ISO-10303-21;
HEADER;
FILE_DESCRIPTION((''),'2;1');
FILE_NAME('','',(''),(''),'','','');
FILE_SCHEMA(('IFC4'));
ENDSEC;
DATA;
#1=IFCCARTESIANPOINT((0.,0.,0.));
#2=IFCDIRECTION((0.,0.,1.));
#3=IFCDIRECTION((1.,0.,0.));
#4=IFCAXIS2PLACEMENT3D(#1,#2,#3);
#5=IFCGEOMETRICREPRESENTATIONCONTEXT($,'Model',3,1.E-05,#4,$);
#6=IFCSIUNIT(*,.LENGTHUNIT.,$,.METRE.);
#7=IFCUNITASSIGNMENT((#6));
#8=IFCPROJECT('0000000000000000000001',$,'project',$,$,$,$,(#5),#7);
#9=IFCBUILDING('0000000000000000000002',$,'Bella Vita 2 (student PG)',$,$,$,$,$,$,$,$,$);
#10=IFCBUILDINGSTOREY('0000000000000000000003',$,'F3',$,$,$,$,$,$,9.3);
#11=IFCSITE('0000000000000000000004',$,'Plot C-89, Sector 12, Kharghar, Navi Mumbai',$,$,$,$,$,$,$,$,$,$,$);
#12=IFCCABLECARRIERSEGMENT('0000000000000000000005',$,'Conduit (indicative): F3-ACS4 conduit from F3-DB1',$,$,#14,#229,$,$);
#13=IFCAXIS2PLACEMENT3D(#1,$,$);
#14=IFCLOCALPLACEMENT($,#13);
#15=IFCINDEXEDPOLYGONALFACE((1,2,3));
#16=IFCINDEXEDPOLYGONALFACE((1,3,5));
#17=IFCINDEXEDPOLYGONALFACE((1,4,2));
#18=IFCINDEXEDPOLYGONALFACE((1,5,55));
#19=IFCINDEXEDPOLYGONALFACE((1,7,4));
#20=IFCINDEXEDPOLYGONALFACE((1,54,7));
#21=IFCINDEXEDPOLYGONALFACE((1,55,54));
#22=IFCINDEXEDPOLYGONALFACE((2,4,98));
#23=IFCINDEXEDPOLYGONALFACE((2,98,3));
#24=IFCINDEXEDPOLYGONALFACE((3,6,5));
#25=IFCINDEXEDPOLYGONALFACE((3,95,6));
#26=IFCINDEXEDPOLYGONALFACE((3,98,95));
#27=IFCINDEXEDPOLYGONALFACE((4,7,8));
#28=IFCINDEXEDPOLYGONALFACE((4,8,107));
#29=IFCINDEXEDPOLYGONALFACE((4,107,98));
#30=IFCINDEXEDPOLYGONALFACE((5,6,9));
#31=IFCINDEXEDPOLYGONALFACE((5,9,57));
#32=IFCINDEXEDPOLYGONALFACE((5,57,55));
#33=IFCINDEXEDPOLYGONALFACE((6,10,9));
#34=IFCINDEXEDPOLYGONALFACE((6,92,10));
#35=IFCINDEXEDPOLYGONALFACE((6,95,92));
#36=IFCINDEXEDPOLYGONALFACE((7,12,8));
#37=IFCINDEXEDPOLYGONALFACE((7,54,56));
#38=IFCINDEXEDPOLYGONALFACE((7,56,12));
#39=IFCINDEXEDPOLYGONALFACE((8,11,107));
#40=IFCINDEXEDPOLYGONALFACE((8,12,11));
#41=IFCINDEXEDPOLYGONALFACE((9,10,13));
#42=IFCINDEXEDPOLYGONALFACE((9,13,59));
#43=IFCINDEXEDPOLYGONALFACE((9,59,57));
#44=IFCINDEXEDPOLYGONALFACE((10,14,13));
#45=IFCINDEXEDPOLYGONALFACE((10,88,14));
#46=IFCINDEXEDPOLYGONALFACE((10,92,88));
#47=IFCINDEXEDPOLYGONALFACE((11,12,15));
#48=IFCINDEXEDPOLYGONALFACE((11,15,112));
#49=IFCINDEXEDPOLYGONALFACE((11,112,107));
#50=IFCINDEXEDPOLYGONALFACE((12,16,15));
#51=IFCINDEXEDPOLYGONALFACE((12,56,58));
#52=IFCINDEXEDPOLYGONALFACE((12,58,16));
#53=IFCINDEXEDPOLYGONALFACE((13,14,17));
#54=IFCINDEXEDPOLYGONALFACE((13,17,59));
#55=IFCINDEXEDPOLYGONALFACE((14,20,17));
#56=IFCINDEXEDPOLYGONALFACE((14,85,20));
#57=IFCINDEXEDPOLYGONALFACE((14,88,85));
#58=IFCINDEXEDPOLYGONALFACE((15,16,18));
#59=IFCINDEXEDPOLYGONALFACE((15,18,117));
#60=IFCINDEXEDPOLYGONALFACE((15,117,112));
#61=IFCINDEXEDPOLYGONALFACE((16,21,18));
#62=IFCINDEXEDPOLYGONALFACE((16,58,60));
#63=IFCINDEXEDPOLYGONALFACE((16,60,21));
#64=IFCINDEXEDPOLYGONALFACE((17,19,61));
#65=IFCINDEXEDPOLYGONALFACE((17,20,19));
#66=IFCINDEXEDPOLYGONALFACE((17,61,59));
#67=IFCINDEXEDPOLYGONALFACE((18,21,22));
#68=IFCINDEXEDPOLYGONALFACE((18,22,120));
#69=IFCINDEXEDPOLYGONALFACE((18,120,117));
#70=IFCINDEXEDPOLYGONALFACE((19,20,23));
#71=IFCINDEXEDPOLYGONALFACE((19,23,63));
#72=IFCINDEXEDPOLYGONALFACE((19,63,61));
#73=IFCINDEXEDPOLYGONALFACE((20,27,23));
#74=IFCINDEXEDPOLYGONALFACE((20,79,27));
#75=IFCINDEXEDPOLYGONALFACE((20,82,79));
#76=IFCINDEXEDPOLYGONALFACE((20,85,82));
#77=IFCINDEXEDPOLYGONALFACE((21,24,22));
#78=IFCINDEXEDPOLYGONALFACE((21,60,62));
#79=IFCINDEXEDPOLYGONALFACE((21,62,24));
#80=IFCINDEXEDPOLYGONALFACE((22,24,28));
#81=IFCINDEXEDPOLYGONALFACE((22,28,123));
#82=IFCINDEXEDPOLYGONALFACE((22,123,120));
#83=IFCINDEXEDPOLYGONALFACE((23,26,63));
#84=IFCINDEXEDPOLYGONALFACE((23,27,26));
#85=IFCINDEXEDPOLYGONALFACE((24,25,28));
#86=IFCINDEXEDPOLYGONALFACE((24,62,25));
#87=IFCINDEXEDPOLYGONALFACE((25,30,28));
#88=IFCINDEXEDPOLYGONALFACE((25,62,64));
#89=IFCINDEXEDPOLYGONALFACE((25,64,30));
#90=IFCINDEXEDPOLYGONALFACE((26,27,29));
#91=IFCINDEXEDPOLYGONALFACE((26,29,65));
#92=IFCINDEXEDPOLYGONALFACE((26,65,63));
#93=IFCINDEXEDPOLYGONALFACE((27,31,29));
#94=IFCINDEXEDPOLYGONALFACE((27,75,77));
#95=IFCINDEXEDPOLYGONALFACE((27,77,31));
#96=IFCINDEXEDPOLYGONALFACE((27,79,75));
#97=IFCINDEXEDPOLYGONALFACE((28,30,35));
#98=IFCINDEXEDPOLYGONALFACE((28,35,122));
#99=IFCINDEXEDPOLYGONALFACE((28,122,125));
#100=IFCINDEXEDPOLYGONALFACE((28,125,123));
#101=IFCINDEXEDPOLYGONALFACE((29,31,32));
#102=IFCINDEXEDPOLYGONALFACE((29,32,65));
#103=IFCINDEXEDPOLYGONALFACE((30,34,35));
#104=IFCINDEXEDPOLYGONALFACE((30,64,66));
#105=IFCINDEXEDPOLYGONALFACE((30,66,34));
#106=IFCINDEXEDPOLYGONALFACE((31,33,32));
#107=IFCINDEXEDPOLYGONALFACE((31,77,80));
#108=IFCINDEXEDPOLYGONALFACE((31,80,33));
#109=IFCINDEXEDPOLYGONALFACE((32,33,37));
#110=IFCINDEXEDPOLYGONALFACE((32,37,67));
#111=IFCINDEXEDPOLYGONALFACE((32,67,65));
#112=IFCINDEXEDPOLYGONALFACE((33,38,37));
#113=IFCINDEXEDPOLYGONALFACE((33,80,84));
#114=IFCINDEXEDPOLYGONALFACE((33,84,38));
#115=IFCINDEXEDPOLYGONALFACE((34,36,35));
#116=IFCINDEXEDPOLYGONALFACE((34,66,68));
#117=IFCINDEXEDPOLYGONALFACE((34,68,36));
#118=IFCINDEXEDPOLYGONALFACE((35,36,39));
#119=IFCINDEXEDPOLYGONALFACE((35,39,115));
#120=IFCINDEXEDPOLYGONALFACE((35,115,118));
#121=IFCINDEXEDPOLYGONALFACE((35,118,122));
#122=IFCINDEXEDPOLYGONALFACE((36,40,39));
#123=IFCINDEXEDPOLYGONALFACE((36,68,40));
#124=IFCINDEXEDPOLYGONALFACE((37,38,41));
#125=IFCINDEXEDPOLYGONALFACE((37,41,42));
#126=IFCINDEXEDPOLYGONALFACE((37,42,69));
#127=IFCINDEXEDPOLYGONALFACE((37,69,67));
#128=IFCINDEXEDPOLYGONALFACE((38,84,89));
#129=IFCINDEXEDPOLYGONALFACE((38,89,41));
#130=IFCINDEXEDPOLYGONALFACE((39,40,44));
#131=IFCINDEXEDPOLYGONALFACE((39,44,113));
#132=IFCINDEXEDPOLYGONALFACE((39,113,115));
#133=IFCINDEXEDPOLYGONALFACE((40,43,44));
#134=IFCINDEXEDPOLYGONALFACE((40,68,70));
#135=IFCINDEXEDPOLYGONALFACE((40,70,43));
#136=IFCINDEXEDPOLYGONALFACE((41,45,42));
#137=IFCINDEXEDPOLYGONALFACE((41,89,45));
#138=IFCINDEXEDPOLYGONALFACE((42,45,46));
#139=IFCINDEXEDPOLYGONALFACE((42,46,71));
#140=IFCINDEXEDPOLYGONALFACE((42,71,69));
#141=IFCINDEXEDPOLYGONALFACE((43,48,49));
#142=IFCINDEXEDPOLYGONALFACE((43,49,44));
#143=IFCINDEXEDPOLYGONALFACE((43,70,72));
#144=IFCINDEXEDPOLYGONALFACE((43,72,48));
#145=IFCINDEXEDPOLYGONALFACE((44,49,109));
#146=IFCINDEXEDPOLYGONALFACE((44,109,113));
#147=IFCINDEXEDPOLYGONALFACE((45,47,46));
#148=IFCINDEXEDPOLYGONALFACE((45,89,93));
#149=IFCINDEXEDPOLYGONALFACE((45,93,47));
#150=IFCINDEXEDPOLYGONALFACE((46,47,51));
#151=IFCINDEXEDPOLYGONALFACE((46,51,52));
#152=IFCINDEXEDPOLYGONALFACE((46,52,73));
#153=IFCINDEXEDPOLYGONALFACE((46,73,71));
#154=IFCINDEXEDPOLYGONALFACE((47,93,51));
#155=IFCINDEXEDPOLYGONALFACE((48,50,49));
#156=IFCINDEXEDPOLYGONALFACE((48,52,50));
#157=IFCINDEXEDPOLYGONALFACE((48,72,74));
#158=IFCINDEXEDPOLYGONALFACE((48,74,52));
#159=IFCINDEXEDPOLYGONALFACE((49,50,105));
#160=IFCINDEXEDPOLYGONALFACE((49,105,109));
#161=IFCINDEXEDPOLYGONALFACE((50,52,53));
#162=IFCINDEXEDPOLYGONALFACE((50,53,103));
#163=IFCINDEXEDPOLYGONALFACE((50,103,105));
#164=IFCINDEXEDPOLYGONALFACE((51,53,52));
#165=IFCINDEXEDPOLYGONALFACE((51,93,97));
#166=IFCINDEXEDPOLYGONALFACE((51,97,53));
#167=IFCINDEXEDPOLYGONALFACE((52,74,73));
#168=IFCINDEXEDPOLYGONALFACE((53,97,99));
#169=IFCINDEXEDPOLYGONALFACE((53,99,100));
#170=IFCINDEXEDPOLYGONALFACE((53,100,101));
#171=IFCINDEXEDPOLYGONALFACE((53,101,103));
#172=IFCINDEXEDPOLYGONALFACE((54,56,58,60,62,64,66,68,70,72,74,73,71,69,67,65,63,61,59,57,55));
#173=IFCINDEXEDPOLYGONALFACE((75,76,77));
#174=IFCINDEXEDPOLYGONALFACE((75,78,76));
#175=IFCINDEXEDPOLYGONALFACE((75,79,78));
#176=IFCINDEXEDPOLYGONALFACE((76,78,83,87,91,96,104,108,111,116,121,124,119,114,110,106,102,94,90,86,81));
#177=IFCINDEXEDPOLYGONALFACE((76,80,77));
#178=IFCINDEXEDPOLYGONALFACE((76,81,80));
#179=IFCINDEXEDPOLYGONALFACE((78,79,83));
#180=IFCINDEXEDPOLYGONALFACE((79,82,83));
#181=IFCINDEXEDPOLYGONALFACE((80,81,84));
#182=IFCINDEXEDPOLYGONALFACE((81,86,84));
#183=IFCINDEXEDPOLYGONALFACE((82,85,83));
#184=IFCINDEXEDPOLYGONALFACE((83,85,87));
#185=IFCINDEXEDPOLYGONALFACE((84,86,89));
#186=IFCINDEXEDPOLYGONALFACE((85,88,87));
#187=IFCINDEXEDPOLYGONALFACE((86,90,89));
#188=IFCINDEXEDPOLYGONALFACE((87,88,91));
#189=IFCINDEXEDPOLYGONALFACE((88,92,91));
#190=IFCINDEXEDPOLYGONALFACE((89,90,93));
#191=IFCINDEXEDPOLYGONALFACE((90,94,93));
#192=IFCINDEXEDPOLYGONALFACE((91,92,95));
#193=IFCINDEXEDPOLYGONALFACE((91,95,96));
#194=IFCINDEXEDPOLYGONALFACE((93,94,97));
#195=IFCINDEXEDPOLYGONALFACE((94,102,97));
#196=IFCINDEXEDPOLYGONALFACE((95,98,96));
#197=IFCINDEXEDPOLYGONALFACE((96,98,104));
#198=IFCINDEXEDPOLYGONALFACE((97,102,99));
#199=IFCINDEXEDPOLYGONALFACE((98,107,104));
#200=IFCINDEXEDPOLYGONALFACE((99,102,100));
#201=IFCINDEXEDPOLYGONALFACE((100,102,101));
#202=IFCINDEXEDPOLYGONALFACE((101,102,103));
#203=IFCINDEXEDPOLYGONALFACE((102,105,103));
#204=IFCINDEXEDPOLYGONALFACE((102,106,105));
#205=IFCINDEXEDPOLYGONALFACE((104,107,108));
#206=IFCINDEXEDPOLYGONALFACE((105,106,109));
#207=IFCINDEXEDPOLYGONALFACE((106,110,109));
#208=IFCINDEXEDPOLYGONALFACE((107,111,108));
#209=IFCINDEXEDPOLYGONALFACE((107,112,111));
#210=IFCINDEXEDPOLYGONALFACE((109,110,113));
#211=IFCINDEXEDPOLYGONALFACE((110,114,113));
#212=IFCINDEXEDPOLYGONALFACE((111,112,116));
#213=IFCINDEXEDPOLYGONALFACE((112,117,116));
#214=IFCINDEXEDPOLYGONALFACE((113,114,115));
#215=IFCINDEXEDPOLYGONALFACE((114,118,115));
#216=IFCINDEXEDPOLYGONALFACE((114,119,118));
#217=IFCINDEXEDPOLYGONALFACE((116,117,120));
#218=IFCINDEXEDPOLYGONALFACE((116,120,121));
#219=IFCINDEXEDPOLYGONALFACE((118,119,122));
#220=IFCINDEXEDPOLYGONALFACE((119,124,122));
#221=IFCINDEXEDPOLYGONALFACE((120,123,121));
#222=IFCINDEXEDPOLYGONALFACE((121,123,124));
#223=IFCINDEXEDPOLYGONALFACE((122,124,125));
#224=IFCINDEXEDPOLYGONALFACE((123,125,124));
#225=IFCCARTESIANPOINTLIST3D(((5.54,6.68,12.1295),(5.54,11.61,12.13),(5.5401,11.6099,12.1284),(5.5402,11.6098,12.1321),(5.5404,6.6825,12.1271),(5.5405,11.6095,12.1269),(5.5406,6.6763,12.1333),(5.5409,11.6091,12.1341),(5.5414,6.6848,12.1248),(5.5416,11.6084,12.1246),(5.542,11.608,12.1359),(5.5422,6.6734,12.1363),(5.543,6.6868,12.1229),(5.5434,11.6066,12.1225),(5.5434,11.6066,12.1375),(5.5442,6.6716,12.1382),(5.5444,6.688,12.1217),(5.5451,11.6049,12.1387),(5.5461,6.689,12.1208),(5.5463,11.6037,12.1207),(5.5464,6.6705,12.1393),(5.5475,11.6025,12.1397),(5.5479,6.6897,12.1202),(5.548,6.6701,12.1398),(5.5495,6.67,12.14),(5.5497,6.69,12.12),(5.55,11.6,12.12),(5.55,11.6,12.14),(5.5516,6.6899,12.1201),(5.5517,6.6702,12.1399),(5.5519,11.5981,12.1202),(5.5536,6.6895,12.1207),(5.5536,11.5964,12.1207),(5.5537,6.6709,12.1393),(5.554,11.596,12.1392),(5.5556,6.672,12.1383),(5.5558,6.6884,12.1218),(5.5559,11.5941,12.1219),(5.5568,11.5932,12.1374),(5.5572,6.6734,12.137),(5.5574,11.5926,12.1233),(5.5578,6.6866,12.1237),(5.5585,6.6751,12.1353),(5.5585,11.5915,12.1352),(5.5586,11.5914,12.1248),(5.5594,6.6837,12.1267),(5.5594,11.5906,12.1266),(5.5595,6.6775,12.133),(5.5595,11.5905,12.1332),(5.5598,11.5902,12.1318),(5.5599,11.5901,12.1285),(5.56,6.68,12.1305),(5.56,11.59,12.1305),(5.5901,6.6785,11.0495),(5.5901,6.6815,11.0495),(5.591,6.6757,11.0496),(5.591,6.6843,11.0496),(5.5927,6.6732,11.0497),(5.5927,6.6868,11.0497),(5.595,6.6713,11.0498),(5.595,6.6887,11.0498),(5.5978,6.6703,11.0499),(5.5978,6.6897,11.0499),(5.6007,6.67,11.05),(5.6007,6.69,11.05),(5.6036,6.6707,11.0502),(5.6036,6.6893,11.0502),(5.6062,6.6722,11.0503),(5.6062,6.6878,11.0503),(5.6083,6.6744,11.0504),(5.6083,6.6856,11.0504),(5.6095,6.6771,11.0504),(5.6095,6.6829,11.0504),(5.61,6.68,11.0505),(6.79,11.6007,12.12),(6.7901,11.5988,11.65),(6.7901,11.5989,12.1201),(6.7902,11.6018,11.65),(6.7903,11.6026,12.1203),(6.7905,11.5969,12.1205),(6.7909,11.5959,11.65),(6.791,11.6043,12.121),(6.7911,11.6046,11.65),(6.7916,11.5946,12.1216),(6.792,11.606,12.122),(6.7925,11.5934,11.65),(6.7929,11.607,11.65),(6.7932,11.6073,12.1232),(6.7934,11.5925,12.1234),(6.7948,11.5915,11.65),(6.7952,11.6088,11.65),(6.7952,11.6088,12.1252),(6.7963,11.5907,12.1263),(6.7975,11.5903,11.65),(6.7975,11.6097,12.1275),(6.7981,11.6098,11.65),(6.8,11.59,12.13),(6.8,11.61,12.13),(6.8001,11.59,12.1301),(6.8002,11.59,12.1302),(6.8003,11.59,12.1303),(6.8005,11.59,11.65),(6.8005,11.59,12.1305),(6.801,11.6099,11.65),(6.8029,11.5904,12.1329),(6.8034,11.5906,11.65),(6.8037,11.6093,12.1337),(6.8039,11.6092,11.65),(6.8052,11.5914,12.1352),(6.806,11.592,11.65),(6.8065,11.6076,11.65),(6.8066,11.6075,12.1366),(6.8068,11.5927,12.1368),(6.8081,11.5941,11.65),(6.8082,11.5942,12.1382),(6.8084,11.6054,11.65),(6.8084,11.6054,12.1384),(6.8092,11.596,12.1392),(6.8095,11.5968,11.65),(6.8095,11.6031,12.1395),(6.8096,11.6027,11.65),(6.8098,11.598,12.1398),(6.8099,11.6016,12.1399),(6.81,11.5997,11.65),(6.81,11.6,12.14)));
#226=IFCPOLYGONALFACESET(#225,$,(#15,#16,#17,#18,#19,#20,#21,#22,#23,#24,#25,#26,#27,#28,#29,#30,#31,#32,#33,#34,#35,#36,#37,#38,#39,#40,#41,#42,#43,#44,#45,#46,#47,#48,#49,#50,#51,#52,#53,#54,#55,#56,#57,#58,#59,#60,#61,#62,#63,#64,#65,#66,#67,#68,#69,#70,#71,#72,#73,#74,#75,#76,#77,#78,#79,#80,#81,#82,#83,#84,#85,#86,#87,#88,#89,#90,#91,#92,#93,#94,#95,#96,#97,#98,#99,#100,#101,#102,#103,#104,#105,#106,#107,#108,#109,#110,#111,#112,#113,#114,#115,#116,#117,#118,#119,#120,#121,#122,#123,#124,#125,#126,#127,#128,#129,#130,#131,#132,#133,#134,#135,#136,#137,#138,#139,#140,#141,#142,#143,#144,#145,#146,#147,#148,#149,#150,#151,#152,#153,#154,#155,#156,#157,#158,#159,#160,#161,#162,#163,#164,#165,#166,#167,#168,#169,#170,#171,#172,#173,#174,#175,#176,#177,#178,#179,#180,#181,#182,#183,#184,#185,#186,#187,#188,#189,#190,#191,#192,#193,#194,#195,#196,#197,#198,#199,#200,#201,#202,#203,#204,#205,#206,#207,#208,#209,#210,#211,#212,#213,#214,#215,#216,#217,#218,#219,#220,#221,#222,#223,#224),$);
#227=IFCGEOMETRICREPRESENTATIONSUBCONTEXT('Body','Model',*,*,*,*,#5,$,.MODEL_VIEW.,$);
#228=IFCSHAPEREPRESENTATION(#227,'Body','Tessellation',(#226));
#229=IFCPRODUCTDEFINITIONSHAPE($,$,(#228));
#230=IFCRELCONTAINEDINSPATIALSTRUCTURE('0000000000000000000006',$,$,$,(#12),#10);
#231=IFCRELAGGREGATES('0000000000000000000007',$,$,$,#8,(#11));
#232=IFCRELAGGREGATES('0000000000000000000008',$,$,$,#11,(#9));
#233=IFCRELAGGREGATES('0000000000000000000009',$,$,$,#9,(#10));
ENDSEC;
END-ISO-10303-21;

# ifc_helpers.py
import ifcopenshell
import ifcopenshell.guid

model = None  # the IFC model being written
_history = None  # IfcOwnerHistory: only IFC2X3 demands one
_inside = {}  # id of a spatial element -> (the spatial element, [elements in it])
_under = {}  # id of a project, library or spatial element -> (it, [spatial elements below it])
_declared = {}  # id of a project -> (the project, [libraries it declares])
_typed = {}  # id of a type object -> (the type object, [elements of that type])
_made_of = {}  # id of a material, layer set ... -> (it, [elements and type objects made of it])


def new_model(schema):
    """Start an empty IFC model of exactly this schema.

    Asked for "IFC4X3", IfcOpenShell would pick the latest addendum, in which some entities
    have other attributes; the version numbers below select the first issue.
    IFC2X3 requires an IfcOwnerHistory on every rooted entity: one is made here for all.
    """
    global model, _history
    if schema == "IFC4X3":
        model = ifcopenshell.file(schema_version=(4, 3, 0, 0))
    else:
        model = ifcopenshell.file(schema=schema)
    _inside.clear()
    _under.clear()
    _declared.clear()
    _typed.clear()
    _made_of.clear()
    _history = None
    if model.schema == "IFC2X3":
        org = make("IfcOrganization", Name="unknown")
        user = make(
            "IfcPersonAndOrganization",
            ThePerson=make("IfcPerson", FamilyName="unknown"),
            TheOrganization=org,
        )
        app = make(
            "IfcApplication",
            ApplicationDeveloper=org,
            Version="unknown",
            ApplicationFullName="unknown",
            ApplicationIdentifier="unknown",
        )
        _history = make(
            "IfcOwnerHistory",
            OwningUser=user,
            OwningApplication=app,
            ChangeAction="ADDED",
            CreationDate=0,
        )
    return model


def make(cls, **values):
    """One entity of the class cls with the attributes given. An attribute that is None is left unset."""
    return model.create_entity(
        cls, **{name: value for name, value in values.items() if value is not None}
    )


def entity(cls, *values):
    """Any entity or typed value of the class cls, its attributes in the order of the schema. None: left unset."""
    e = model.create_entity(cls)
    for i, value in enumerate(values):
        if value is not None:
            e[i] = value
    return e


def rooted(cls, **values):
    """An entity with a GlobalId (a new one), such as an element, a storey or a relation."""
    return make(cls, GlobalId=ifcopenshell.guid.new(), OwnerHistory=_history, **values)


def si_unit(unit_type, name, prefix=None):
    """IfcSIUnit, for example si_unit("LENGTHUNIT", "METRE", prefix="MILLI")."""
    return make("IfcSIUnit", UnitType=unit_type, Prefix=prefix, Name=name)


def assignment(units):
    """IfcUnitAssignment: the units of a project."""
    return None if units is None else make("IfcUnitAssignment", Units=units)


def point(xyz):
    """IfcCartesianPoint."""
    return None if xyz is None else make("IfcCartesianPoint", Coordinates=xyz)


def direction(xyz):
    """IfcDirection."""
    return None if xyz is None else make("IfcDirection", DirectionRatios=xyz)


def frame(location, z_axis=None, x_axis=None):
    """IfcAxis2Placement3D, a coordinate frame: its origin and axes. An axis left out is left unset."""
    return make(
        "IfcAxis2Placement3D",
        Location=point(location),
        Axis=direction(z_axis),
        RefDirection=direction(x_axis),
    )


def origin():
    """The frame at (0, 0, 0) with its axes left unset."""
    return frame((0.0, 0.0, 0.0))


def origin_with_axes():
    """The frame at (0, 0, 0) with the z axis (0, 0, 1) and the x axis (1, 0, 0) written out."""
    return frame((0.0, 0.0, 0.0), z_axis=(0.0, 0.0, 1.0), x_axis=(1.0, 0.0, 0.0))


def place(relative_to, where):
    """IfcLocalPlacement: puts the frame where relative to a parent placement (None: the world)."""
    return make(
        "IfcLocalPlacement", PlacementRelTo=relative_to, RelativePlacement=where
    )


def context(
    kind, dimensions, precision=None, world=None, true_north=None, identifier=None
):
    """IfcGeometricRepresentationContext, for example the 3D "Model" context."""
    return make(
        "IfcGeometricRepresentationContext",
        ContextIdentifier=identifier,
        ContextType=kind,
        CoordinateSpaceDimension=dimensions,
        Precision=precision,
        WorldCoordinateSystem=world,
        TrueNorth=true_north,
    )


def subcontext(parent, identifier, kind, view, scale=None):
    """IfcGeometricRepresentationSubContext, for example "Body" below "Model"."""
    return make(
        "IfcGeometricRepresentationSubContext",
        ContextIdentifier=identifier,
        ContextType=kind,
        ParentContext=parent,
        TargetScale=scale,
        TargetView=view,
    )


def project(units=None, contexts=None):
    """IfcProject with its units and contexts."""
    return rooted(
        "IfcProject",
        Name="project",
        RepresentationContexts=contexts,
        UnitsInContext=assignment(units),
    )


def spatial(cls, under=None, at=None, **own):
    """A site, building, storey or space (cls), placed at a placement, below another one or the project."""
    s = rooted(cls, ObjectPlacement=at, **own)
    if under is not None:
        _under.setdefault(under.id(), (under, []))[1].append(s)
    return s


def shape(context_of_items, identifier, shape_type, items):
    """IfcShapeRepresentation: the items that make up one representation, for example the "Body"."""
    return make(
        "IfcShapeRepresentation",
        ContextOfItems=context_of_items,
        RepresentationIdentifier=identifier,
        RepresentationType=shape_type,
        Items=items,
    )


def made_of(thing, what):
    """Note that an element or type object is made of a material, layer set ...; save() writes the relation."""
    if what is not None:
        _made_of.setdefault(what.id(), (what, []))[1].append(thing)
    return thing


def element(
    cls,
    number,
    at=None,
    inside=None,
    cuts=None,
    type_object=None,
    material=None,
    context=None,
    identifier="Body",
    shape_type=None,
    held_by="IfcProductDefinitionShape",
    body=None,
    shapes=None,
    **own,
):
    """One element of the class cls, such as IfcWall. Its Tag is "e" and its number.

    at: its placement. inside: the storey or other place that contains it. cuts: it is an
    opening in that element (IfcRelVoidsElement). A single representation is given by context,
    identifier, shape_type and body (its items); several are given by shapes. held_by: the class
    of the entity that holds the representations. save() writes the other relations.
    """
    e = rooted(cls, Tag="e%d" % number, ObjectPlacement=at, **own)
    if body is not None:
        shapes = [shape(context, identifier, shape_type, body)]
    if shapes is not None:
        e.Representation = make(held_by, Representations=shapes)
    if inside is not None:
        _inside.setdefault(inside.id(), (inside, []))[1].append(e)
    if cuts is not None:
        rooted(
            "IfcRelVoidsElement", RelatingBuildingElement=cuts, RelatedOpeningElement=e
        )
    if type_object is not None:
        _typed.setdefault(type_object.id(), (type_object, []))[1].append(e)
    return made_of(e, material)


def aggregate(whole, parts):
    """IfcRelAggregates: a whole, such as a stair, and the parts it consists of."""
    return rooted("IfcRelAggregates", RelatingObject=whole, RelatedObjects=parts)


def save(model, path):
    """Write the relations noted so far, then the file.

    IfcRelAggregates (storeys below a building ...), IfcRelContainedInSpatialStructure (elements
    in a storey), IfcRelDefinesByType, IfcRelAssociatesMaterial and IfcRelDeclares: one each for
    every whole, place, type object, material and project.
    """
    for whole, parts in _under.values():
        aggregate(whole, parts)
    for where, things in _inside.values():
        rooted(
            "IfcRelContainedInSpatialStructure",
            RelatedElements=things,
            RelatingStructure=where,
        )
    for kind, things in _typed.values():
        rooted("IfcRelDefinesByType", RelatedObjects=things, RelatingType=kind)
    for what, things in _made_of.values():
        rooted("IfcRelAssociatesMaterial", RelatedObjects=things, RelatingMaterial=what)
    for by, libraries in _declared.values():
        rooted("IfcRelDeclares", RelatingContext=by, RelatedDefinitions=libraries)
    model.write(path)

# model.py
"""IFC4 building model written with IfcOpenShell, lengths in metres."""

from ifc_helpers import new_model, entity, si_unit, origin, origin_with_axes, place, context, subcontext, project, spatial, element, save


model = new_model("IFC4")

# Units and contexts
model_context = context("Model", 3, precision=1e-05, world=origin_with_axes())
body_context = subcontext(model_context, "Body", "Model", "MODEL_VIEW")
ifc_project = project(units=[si_unit("LENGTHUNIT", "METRE")], contexts=[model_context])

# Site, building, storey
site = spatial("IfcSite", under=ifc_project, Name="Plot C-89, Sector 12, Kharghar, Navi Mumbai")
building = spatial("IfcBuilding", under=site, Name="Bella Vita 2 (student PG)")
storey = spatial("IfcBuildingStorey", under=building, Name="F3", Elevation=9.3)

# Cable carrier segment
cable_carrier_segment_1_placement = place(None, origin())
element("IfcCableCarrierSegment", 1, at=cable_carrier_segment_1_placement, inside=storey, Name="Conduit (indicative): F3-ACS4 conduit from F3-DB1", context=body_context, shape_type="AdvancedSweptSolid", body=[
    entity("IfcSweptDiskSolid", entity("IfcPolyline", [entity("IfcCartesianPoint", [5.6, 6.68, 11.05]), entity("IfcCartesianPoint", [5.55, 6.68, 12.13]), entity("IfcCartesianPoint", [5.55, 11.6, 12.13]), entity("IfcCartesianPoint", [6.8, 11.6, 12.13]), entity("IfcCartesianPoint", [6.8, 11.6, 11.65])]), 0.01),
])

save(model, "model.ifc")
